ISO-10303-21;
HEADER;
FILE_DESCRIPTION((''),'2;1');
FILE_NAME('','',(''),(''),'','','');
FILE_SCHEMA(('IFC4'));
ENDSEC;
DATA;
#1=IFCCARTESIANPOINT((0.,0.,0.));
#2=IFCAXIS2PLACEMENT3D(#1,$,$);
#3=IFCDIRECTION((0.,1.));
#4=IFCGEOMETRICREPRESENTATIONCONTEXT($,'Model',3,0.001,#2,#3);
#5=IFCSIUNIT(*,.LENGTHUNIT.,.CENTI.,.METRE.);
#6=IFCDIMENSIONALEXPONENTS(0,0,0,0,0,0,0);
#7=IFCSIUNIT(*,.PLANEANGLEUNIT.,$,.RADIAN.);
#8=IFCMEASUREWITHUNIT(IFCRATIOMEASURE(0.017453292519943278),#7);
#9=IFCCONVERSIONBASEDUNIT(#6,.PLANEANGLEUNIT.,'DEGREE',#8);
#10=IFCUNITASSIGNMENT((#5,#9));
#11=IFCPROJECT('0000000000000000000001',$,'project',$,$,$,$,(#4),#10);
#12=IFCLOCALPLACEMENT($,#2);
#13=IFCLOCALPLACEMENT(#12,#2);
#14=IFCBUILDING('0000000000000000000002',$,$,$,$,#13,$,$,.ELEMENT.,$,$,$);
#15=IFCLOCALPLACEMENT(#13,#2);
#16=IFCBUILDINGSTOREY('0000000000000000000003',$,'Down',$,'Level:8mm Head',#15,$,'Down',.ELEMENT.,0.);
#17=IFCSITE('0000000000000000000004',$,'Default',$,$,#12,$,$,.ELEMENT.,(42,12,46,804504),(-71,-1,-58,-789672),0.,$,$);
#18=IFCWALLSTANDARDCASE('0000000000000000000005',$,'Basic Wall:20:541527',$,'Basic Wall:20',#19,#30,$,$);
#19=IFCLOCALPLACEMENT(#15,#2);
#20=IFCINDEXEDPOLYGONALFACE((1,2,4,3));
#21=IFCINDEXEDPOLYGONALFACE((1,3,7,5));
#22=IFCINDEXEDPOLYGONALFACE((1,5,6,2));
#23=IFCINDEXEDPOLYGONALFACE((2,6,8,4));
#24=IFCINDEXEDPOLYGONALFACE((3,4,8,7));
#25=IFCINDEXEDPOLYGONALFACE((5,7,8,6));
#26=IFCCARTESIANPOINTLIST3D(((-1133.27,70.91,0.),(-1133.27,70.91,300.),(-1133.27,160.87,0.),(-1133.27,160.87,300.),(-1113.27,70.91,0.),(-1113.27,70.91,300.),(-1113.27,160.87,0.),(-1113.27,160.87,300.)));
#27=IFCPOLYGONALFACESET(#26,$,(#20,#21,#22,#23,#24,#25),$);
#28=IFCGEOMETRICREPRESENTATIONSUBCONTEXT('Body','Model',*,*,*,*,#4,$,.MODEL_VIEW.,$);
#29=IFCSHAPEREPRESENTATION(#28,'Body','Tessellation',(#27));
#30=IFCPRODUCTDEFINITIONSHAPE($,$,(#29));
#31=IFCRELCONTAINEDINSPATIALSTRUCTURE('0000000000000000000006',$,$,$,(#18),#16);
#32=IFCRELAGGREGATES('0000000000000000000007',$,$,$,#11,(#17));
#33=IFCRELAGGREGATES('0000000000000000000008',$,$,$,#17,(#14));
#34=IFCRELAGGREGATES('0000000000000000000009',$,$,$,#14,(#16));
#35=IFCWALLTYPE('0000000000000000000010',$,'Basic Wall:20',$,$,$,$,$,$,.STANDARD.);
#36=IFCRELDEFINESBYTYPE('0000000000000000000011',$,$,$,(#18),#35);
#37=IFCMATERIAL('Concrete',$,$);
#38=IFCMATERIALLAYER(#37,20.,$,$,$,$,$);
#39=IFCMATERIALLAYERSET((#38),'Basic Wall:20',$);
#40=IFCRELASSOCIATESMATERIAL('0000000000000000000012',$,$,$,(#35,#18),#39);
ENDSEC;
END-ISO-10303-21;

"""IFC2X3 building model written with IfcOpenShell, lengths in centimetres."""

from ifc_helpers import new_model, entity, si_unit, converted_unit, direction, frame, frame_2d, origin, place, context, subcontext, project, spatial, rectangle, extrude, material, layer, layer_set, layer_usage, type_object, element, save


model = new_model("IFC2X3")

# Units and contexts
model_context = context("Model", 3, precision=0.001, world=origin(), true_north=direction((0.0, 1.0)))
body_context = subcontext(model_context, "Body", "Model", "MODEL_VIEW")
ifc_project = project(units=[si_unit("LENGTHUNIT", "METRE", prefix="CENTI"), converted_unit("PLANEANGLEUNIT", "DEGREE", entity("IfcRatioMeasure", 0.017453292519943278), si_unit("PLANEANGLEUNIT", "RADIAN"), dimensions=[0, 0, 0, 0, 0, 0, 0])], contexts=[model_context])

# Site, building, storey
site_placement = place(None, origin())
site = spatial("IfcSite", under=ifc_project, at=site_placement, Name="Default", CompositionType="ELEMENT", RefLatitude=(42, 12, 46, 804504), RefLongitude=(-71, -1, -58, -789672), RefElevation=0.0)
building_placement = place(site_placement, origin())
building = spatial("IfcBuilding", under=site, at=building_placement, CompositionType="ELEMENT")
storey_placement = place(building_placement, origin())
storey = spatial("IfcBuildingStorey", under=building, at=storey_placement, Name="Down", ObjectType="Level:8mm Head", LongName="Down", CompositionType="ELEMENT", Elevation=0.0)

# Shared definitions
ifc_material = material(Name="Concrete")

# Wall
ifc_layer_1 = layer(ifc_material, 20.0)
ifc_layer_set_1 = layer_set([ifc_layer_1], Name="Basic Wall:20")
wall_type_1 = type_object("IfcWallType", Name="Basic Wall:20", PredefinedType="STANDARD", material=ifc_layer_set_1)
ifc_layer_usage_1 = layer_usage(ifc_layer_set_1, "AXIS2", "NEGATIVE", 10.0)
wall_1_placement = place(storey_placement, frame((-1123.27, 70.91, 0.0), z_axis=(0.0, 0.0, 1.0), x_axis=(0.0, 1.0, 0.0)))
element("IfcWallStandardCase", 1, at=wall_1_placement, inside=storey, type_object=wall_type_1, material=ifc_layer_usage_1, Name="Basic Wall:20:541527", ObjectType="Basic Wall:20", context=body_context, shape_type="SweptSolid", body=[
    extrude(rectangle(XDim=89.95, YDim=20.0, at=frame_2d((44.98, 0.0), x_axis=(-1.0, 0.0))), origin(), (0.0, 0.0, 1.0), 300.0),
])

save(model, "model.ifc")
